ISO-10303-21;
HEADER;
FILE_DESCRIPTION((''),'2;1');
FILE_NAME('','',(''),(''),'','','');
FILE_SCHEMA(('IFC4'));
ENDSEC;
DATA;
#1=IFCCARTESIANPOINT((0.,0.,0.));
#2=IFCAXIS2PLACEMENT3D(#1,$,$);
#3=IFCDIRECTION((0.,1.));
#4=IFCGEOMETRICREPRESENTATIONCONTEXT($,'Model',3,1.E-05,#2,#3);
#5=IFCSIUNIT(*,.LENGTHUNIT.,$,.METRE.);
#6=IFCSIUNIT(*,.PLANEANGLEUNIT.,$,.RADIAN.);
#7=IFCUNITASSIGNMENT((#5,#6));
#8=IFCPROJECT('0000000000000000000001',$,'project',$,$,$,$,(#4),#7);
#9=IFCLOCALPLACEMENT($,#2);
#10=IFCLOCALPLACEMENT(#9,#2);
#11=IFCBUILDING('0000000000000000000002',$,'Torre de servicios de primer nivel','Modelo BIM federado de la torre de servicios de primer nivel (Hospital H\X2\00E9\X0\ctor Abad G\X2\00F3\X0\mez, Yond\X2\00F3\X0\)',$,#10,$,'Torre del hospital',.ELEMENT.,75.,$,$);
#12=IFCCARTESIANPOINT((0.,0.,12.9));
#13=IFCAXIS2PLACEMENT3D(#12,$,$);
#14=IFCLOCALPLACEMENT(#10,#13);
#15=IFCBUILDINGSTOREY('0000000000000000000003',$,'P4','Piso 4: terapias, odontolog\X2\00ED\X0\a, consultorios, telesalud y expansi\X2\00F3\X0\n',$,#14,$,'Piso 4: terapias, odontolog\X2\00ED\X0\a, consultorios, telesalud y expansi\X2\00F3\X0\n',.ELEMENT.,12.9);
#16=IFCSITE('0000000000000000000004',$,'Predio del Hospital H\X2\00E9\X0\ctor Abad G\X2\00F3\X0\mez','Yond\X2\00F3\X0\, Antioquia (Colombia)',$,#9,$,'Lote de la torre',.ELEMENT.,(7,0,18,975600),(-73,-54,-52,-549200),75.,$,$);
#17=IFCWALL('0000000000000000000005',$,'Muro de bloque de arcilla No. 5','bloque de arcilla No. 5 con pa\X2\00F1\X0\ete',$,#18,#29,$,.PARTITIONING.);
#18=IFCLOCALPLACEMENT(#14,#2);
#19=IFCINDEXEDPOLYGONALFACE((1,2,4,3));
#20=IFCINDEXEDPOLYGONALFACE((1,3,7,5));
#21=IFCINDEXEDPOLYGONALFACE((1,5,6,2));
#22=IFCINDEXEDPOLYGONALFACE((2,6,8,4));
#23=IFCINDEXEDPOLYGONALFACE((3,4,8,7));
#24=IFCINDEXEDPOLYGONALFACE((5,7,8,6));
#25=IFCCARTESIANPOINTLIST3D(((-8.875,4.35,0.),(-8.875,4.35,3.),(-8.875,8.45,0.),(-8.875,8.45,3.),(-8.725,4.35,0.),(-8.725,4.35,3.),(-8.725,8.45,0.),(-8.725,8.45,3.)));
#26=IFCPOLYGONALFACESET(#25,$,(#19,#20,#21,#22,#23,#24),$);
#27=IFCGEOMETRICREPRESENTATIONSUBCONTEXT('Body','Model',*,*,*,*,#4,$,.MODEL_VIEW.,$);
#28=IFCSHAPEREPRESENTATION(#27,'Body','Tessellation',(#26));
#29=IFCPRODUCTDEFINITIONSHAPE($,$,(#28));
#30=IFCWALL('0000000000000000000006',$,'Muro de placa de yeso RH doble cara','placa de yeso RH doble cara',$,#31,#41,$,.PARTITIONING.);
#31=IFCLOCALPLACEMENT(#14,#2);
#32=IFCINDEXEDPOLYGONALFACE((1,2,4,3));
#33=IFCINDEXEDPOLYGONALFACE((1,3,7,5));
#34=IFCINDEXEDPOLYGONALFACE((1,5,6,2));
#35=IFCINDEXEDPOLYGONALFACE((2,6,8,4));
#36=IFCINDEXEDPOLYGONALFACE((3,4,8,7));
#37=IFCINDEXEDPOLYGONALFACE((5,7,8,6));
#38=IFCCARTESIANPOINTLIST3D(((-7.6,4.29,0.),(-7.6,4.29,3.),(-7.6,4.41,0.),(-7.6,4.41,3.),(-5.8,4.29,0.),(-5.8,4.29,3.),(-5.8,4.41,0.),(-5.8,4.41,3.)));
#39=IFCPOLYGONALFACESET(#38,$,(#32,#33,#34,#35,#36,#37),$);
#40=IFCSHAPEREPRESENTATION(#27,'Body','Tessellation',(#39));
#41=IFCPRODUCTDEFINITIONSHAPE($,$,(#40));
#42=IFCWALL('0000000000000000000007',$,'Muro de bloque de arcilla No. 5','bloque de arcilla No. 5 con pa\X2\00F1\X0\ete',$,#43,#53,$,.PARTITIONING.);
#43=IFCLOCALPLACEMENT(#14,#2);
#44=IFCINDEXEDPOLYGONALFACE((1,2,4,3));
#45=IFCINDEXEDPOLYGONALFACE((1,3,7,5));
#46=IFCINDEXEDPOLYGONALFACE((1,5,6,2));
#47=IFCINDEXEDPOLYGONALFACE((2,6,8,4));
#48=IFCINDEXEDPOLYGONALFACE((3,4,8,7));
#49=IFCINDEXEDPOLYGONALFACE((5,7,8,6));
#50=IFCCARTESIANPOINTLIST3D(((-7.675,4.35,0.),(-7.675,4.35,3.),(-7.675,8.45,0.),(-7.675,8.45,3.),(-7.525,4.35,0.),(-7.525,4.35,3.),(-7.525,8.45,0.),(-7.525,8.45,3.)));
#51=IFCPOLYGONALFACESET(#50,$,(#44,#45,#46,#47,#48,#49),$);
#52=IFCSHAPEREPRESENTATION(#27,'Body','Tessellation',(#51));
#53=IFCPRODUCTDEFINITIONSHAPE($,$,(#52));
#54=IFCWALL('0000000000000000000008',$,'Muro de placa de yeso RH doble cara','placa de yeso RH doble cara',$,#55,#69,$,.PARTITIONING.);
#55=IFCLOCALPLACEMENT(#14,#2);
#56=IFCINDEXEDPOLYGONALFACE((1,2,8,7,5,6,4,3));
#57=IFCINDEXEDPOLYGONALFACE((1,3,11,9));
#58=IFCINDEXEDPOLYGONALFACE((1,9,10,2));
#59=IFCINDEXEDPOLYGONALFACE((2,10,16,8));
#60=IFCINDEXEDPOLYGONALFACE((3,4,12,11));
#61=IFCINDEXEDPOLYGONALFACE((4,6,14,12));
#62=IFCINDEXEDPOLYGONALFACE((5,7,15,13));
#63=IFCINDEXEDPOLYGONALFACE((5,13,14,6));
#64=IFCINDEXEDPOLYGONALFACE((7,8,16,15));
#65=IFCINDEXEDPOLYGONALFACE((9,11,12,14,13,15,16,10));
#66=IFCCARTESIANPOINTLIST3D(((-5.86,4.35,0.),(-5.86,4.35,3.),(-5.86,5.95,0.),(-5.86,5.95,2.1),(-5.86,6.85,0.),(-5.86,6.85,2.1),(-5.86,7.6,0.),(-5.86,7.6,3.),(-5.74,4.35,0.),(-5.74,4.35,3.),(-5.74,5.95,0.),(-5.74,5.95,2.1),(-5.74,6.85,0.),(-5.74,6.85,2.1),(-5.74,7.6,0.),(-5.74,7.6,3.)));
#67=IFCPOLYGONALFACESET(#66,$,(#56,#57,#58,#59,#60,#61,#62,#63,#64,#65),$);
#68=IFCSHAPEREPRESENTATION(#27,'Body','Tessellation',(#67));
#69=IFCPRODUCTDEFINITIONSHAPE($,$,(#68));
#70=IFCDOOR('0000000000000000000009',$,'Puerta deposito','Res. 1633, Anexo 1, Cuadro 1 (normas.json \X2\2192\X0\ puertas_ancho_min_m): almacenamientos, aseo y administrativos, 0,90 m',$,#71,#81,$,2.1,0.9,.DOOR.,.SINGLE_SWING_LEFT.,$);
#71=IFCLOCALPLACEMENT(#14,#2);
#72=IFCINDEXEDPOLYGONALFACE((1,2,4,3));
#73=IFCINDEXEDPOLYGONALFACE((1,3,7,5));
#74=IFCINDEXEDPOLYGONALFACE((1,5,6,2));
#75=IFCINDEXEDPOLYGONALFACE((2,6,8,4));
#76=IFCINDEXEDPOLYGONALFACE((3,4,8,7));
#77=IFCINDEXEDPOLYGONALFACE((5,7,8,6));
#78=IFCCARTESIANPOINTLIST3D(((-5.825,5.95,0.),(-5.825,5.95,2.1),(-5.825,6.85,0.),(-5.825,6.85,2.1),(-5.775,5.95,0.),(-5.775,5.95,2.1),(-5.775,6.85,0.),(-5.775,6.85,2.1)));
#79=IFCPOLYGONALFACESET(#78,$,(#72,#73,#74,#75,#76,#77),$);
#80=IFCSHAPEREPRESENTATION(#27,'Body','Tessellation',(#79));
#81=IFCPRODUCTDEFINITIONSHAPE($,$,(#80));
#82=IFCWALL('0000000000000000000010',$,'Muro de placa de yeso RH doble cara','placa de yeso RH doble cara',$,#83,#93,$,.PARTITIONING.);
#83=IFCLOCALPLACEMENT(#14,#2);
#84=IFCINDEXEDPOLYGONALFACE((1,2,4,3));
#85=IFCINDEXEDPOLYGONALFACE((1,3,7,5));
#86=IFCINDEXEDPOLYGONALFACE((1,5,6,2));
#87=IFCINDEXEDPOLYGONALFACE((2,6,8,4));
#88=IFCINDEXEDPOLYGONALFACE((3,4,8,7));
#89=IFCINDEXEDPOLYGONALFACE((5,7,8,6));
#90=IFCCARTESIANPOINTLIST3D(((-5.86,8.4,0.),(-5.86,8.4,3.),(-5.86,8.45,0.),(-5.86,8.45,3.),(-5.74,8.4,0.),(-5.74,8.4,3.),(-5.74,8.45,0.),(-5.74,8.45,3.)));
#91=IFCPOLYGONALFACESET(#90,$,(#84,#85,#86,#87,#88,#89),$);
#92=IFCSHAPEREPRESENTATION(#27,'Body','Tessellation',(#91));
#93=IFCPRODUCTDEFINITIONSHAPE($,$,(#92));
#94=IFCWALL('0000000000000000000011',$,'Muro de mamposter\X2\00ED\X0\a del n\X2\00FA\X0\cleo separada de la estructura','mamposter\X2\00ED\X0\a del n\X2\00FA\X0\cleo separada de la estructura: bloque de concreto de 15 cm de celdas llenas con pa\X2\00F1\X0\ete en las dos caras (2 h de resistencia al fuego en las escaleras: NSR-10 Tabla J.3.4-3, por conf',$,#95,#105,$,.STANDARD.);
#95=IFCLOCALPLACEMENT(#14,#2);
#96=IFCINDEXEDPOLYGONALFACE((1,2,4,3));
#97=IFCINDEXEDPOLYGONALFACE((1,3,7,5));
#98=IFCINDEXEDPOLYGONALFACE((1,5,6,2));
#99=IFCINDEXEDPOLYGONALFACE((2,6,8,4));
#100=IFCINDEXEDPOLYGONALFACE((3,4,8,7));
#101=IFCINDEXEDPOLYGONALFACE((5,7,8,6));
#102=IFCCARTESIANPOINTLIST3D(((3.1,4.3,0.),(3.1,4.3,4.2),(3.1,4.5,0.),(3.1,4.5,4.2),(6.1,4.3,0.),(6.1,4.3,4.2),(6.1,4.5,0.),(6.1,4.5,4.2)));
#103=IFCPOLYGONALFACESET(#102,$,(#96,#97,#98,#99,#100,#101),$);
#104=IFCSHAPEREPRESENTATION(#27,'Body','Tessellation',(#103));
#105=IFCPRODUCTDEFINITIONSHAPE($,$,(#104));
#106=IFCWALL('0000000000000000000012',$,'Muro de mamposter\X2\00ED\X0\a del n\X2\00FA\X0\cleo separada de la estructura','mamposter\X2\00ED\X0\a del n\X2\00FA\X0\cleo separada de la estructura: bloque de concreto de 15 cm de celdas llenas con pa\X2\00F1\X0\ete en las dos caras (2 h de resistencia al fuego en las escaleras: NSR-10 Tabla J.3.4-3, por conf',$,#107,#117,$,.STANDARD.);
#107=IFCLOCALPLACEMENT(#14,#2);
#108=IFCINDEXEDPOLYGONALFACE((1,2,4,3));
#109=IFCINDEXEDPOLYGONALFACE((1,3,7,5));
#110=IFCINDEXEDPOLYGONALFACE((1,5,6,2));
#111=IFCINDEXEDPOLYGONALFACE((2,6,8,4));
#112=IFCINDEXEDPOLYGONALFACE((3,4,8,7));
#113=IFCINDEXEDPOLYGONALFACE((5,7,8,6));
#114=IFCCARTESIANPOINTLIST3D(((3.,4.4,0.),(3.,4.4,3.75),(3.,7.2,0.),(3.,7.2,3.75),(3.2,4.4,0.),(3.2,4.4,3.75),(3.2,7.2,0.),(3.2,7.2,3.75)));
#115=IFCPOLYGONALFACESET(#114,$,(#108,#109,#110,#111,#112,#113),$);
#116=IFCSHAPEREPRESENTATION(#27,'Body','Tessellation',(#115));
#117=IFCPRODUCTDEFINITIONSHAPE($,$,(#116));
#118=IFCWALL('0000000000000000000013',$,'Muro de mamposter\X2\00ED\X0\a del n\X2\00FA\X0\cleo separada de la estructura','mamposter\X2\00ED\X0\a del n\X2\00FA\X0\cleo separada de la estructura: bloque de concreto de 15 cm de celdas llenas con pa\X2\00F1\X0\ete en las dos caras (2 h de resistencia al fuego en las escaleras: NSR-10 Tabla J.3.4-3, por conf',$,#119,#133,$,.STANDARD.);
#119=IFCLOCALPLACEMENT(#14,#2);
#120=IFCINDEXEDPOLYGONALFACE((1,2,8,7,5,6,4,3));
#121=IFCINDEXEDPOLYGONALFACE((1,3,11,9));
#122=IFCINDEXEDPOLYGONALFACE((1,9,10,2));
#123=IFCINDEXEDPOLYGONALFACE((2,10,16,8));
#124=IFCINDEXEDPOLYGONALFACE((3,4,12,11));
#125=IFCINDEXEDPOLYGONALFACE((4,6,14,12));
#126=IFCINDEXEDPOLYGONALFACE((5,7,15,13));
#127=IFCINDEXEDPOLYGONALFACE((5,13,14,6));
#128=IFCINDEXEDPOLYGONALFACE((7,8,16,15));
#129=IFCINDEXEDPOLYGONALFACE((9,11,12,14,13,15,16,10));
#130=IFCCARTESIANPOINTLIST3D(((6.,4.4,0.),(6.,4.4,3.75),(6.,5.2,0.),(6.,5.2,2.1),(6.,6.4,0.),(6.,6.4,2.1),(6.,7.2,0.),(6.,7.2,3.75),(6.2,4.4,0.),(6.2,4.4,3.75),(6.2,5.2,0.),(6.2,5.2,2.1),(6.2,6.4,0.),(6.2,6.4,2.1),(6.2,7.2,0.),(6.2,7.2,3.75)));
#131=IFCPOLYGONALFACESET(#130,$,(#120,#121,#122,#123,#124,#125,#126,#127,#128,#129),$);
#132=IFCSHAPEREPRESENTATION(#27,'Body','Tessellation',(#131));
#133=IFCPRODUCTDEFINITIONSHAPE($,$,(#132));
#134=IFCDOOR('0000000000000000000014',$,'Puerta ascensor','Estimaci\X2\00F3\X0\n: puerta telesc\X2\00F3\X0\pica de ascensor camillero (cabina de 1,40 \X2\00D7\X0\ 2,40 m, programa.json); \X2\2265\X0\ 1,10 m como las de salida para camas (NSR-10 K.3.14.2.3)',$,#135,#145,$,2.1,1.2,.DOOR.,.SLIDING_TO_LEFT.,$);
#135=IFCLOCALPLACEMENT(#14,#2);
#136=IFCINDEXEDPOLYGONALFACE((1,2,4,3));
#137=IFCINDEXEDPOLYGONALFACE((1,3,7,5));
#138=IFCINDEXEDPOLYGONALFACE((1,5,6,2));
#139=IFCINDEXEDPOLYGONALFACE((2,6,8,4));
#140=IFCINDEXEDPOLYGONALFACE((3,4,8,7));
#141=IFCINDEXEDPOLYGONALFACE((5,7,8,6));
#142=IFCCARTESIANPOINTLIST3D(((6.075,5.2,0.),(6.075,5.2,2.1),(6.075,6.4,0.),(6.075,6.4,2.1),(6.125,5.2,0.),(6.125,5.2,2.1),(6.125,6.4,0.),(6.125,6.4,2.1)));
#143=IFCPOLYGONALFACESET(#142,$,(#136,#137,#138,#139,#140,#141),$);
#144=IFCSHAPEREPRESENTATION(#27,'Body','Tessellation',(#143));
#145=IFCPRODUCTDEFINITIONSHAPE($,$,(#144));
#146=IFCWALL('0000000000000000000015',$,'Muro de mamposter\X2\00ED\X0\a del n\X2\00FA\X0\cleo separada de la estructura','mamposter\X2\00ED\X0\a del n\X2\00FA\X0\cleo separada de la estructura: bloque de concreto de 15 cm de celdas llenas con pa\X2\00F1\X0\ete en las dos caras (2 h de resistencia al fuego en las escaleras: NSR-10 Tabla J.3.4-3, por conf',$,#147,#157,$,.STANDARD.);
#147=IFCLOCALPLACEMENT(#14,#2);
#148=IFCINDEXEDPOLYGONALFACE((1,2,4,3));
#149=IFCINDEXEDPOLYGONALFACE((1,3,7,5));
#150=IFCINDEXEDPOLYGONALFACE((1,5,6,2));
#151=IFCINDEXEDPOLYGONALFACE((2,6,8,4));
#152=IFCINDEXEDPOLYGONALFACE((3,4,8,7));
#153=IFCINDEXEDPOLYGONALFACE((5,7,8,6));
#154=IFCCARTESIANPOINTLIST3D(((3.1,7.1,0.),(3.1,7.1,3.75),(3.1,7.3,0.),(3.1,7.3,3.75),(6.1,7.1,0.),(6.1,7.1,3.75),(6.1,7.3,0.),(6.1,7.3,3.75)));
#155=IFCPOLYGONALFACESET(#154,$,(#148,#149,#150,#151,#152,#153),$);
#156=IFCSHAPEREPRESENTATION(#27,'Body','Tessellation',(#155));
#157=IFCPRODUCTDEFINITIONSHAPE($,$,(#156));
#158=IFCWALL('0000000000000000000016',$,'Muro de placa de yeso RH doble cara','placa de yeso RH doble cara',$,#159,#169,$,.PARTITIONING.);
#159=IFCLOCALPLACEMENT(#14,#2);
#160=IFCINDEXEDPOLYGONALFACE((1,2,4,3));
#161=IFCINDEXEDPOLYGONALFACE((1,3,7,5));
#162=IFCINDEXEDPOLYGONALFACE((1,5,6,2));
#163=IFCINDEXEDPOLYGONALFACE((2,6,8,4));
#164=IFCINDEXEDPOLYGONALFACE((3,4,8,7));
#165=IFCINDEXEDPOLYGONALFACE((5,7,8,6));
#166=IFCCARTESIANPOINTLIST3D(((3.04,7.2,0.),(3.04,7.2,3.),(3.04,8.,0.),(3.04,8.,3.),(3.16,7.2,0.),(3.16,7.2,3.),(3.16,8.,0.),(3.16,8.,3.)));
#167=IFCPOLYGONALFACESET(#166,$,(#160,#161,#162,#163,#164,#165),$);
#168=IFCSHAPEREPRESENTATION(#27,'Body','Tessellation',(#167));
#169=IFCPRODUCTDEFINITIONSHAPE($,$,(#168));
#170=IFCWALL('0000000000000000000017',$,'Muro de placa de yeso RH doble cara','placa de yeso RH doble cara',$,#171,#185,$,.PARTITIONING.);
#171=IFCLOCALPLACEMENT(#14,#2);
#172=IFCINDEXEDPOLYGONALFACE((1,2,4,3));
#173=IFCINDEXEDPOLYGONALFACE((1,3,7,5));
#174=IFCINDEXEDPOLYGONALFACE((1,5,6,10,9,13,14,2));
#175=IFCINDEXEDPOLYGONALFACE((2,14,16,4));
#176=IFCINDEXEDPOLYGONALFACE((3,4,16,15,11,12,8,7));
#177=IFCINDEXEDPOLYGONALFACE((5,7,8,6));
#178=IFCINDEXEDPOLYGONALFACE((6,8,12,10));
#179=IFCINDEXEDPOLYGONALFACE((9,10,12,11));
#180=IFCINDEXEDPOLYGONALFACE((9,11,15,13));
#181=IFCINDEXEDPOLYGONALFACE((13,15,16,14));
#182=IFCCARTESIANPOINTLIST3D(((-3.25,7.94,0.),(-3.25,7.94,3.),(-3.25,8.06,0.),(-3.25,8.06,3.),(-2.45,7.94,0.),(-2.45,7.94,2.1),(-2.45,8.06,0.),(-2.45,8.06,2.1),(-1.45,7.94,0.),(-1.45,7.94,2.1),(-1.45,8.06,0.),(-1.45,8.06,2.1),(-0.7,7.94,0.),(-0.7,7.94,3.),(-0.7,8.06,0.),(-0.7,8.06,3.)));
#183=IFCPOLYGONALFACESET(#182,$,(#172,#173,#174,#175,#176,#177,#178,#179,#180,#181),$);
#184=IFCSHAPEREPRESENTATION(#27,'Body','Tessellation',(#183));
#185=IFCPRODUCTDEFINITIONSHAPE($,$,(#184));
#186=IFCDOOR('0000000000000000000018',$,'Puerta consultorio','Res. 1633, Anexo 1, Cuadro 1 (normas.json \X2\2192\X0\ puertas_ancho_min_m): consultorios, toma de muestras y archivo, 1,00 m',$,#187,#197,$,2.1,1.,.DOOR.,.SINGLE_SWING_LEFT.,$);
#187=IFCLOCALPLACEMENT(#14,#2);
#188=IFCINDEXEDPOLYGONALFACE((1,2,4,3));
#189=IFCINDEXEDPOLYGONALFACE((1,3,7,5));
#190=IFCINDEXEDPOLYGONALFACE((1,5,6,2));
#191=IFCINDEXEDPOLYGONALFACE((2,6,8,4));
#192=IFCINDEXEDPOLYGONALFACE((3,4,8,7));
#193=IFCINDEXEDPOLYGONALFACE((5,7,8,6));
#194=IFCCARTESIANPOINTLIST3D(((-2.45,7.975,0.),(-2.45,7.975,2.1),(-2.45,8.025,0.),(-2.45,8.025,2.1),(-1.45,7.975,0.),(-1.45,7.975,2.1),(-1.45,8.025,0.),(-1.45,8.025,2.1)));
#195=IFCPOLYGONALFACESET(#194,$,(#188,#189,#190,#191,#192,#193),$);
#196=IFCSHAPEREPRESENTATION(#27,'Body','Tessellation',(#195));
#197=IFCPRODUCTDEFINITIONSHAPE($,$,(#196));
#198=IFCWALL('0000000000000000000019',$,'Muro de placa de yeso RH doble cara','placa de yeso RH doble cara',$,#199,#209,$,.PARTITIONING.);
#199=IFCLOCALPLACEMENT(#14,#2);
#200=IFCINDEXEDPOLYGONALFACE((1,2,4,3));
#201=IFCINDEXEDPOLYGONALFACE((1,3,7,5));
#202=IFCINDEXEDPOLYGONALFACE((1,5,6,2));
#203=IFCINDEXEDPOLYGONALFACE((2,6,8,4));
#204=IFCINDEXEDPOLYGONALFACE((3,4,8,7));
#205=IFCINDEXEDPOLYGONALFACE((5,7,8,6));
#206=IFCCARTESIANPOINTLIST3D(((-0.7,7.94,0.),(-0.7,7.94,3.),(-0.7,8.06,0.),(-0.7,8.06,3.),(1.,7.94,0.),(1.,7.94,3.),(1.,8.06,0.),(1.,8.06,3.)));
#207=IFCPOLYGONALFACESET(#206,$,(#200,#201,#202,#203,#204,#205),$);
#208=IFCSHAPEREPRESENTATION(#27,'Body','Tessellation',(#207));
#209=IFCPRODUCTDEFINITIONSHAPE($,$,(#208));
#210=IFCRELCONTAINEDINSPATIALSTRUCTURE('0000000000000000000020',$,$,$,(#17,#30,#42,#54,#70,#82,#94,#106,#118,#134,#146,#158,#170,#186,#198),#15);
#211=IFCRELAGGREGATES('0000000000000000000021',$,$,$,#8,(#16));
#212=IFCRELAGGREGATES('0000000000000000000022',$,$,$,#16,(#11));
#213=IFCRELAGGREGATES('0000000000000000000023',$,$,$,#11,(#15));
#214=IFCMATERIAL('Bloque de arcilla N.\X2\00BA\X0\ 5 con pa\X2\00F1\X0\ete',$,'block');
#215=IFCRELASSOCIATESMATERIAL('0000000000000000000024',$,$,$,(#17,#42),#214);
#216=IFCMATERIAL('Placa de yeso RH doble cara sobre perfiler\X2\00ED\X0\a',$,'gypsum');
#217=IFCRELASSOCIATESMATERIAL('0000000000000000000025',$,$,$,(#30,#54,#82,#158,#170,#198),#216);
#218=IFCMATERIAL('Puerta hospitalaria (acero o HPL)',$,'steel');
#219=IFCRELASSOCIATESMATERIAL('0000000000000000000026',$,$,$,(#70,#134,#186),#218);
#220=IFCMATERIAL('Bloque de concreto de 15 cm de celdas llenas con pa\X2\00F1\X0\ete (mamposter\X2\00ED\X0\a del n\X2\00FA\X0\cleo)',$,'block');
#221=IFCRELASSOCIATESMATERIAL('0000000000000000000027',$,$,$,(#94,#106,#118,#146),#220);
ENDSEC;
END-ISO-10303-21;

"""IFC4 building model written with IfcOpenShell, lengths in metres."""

from ifc_helpers import new_model, si_unit, direction, frame, origin, place, context, subcontext, project, spatial, rectangle, extrude, material, element, fill, save


model = new_model("IFC4")

# Units and contexts
model_context = context("Model", 3, precision=1e-05, world=origin(), true_north=direction((0.0, 1.0)))
body_context = subcontext(model_context, "Body", "Model", "MODEL_VIEW")
ifc_project = project(units=[si_unit("LENGTHUNIT", "METRE"), si_unit("PLANEANGLEUNIT", "RADIAN")], contexts=[model_context])

# Site, building, storey
site_placement = place(None, origin())
site = spatial("IfcSite", under=ifc_project, at=site_placement, Name="Predio del Hospital Héctor Abad Gómez", Description="Yondó, Antioquia (Colombia)", LongName="Lote de la torre", CompositionType="ELEMENT", RefLatitude=(7, 0, 18, 975600), RefLongitude=(-73, -54, -52, -549200), RefElevation=75.0)
building_placement = place(site_placement, origin())
building = spatial("IfcBuilding", under=site, at=building_placement, Name="Torre de servicios de primer nivel", Description="Modelo BIM federado de la torre de servicios de primer nivel (Hospital Héctor Abad Gómez, Yondó)", LongName="Torre del hospital", CompositionType="ELEMENT", ElevationOfRefHeight=75.0)
placement = place(building_placement, frame((0.0, 0.0, 12.9)))
storey = spatial("IfcBuildingStorey", under=building, at=placement, Name="P4", Description="Piso 4: terapias, odontología, consultorios, telesalud y expansión", LongName="Piso 4: terapias, odontología, consultorios, telesalud y expansión", CompositionType="ELEMENT", Elevation=12.9)

# Walls
ifc_material_1 = material(Name="Bloque de arcilla N.º 5 con pañete", Category="block")
element("IfcWall", 1, at=placement, inside=storey, material=ifc_material_1, Name="Muro de bloque de arcilla No. 5", Description="bloque de arcilla No. 5 con pañete", PredefinedType="PARTITIONING", context=body_context, shape_type="SweptSolid", body=[
    extrude(rectangle(XDim=0.15, YDim=4.1), frame((-8.8, 6.4, 0.0)), (0.0, 0.0, 1.0), 3.0),
])
ifc_material_2 = material(Name="Placa de yeso RH doble cara sobre perfilería", Category="gypsum")
element("IfcWall", 2, at=placement, inside=storey, material=ifc_material_2, Name="Muro de placa de yeso RH doble cara", Description="placa de yeso RH doble cara", PredefinedType="PARTITIONING", context=body_context, shape_type="SweptSolid", body=[
    extrude(rectangle(XDim=1.8, YDim=0.12), frame((-6.7, 4.35, 0.0)), (0.0, 0.0, 1.0), 3.0),
])
element("IfcWall", 3, at=placement, inside=storey, material=ifc_material_1, Name="Muro de bloque de arcilla No. 5", Description="bloque de arcilla No. 5 con pañete", PredefinedType="PARTITIONING", context=body_context, shape_type="SweptSolid", body=[
    extrude(rectangle(XDim=0.15, YDim=4.1), frame((-7.6, 6.4, 0.0)), (0.0, 0.0, 1.0), 3.0),
])

# Wall, opening, door
wall_1 = element("IfcWall", 4, at=placement, inside=storey, material=ifc_material_2, Name="Muro de placa de yeso RH doble cara", Description="placa de yeso RH doble cara", PredefinedType="PARTITIONING", context=body_context, shape_type="SweptSolid", body=[
    extrude(rectangle(XDim=0.12, YDim=3.25), frame((-5.8, 5.975, 0.0)), (0.0, 0.0, 1.0), 3.0),
])
opening_1 = element("IfcOpeningElement", 5, at=placement, cuts=wall_1, PredefinedType="OPENING", context=body_context, shape_type="SweptSolid", body=[
    extrude(rectangle(XDim=0.22, YDim=0.9), frame((-5.8, 6.4, 0.0)), (0.0, 0.0, 1.0), 2.1),
])
ifc_material_3 = material(Name="Puerta hospitalaria (acero o HPL)", Category="steel")
door_1 = element("IfcDoor", 6, at=placement, inside=storey, material=ifc_material_3, Name="Puerta deposito", Description="Res. 1633, Anexo 1, Cuadro 1 (normas.json → puertas_ancho_min_m): almacenamientos, aseo y administrativos, 0,90 m", OperationType="SINGLE_SWING_LEFT", OverallHeight=2.1, OverallWidth=0.9, PredefinedType="DOOR", context=body_context, shape_type="SweptSolid", body=[
    extrude(rectangle(XDim=0.05, YDim=0.9), frame((-5.8, 6.4, 0.0)), (0.0, 0.0, 1.0), 2.1),
])
fill(opening_1, door_1)

# Walls
element("IfcWall", 7, at=placement, inside=storey, material=ifc_material_2, Name="Muro de placa de yeso RH doble cara", Description="placa de yeso RH doble cara", PredefinedType="PARTITIONING", context=body_context, shape_type="SweptSolid", body=[
    extrude(rectangle(XDim=0.12, YDim=0.05), frame((-5.8, 8.425, 0.0)), (0.0, 0.0, 1.0), 3.0),
])
ifc_material_4 = material(Name="Bloque de concreto de 15 cm de celdas llenas con pañete (mampostería del núcleo)", Category="block")
element("IfcWall", 8, at=placement, inside=storey, material=ifc_material_4, Name="Muro de mampostería del núcleo separada de la estructura", Description="mampostería del núcleo separada de la estructura: bloque de concreto de 15 cm de celdas llenas con pañete en las dos caras (2 h de resistencia al fuego en las escaleras: NSR-10 Tabla J.3.4-3, por conf", PredefinedType="STANDARD", context=body_context, shape_type="SweptSolid", body=[
    extrude(rectangle(XDim=3.0, YDim=0.2), frame((4.6, 4.4, 0.0)), (0.0, 0.0, 1.0), 4.2),
])
element("IfcWall", 9, at=placement, inside=storey, material=ifc_material_4, Name="Muro de mampostería del núcleo separada de la estructura", Description="mampostería del núcleo separada de la estructura: bloque de concreto de 15 cm de celdas llenas con pañete en las dos caras (2 h de resistencia al fuego en las escaleras: NSR-10 Tabla J.3.4-3, por conf", PredefinedType="STANDARD", context=body_context, shape_type="SweptSolid", body=[
    extrude(rectangle(XDim=0.2, YDim=2.8), frame((3.1, 5.8, 0.0)), (0.0, 0.0, 1.0), 3.75),
])

# Wall, opening, door
wall_2 = element("IfcWall", 10, at=placement, inside=storey, material=ifc_material_4, Name="Muro de mampostería del núcleo separada de la estructura", Description="mampostería del núcleo separada de la estructura: bloque de concreto de 15 cm de celdas llenas con pañete en las dos caras (2 h de resistencia al fuego en las escaleras: NSR-10 Tabla J.3.4-3, por conf", PredefinedType="STANDARD", context=body_context, shape_type="SweptSolid", body=[
    extrude(rectangle(XDim=0.2, YDim=2.8), frame((6.1, 5.8, 0.0)), (0.0, 0.0, 1.0), 3.75),
])
opening_2 = element("IfcOpeningElement", 11, at=placement, cuts=wall_2, PredefinedType="OPENING", context=body_context, shape_type="SweptSolid", body=[
    extrude(rectangle(XDim=0.3, YDim=1.2), frame((6.1, 5.8, 0.0)), (0.0, 0.0, 1.0), 2.1),
])
door_2 = element("IfcDoor", 12, at=placement, inside=storey, material=ifc_material_3, Name="Puerta ascensor", Description="Estimación: puerta telescópica de ascensor camillero (cabina de 1,40 × 2,40 m, programa.json); ≥ 1,10 m como las de salida para camas (NSR-10 K.3.14.2.3)", OperationType="SLIDING_TO_LEFT", OverallHeight=2.1, OverallWidth=1.2, PredefinedType="DOOR", context=body_context, shape_type="SweptSolid", body=[
    extrude(rectangle(XDim=0.05, YDim=1.2), frame((6.1, 5.8, 0.0)), (0.0, 0.0, 1.0), 2.1),
])
fill(opening_2, door_2)

# Walls
element("IfcWall", 13, at=placement, inside=storey, material=ifc_material_4, Name="Muro de mampostería del núcleo separada de la estructura", Description="mampostería del núcleo separada de la estructura: bloque de concreto de 15 cm de celdas llenas con pañete en las dos caras (2 h de resistencia al fuego en las escaleras: NSR-10 Tabla J.3.4-3, por conf", PredefinedType="STANDARD", context=body_context, shape_type="SweptSolid", body=[
    extrude(rectangle(XDim=3.0, YDim=0.2), frame((4.6, 7.2, 0.0)), (0.0, 0.0, 1.0), 3.75),
])
element("IfcWall", 14, at=placement, inside=storey, material=ifc_material_2, Name="Muro de placa de yeso RH doble cara", Description="placa de yeso RH doble cara", PredefinedType="PARTITIONING", context=body_context, shape_type="SweptSolid", body=[
    extrude(rectangle(XDim=0.12, YDim=0.8), frame((3.1, 7.6, 0.0)), (0.0, 0.0, 1.0), 3.0),
])

# Wall, opening, door
wall_3 = element("IfcWall", 15, at=placement, inside=storey, material=ifc_material_2, Name="Muro de placa de yeso RH doble cara", Description="placa de yeso RH doble cara", PredefinedType="PARTITIONING", context=body_context, shape_type="SweptSolid", body=[
    extrude(rectangle(XDim=2.55, YDim=0.12), frame((-1.975, 8.0, 0.0)), (0.0, 0.0, 1.0), 3.0),
])
opening_3 = element("IfcOpeningElement", 16, at=placement, cuts=wall_3, PredefinedType="OPENING", context=body_context, shape_type="SweptSolid", body=[
    extrude(rectangle(XDim=1.0, YDim=0.22), frame((-1.95, 8.0, 0.0)), (0.0, 0.0, 1.0), 2.1),
])
door_3 = element("IfcDoor", 17, at=placement, inside=storey, material=ifc_material_3, Name="Puerta consultorio", Description="Res. 1633, Anexo 1, Cuadro 1 (normas.json → puertas_ancho_min_m): consultorios, toma de muestras y archivo, 1,00 m", OperationType="SINGLE_SWING_LEFT", OverallHeight=2.1, OverallWidth=1.0, PredefinedType="DOOR", context=body_context, shape_type="SweptSolid", body=[
    extrude(rectangle(XDim=1.0, YDim=0.05), frame((-1.95, 8.0, 0.0)), (0.0, 0.0, 1.0), 2.1),
])
fill(opening_3, door_3)

# Wall
element("IfcWall", 18, at=placement, inside=storey, material=ifc_material_2, Name="Muro de placa de yeso RH doble cara", Description="placa de yeso RH doble cara", PredefinedType="PARTITIONING", context=body_context, shape_type="SweptSolid", body=[
    extrude(rectangle(XDim=1.7, YDim=0.12), frame((0.15, 8.0, 0.0)), (0.0, 0.0, 1.0), 3.0),
])

save(model, "model.ifc")
